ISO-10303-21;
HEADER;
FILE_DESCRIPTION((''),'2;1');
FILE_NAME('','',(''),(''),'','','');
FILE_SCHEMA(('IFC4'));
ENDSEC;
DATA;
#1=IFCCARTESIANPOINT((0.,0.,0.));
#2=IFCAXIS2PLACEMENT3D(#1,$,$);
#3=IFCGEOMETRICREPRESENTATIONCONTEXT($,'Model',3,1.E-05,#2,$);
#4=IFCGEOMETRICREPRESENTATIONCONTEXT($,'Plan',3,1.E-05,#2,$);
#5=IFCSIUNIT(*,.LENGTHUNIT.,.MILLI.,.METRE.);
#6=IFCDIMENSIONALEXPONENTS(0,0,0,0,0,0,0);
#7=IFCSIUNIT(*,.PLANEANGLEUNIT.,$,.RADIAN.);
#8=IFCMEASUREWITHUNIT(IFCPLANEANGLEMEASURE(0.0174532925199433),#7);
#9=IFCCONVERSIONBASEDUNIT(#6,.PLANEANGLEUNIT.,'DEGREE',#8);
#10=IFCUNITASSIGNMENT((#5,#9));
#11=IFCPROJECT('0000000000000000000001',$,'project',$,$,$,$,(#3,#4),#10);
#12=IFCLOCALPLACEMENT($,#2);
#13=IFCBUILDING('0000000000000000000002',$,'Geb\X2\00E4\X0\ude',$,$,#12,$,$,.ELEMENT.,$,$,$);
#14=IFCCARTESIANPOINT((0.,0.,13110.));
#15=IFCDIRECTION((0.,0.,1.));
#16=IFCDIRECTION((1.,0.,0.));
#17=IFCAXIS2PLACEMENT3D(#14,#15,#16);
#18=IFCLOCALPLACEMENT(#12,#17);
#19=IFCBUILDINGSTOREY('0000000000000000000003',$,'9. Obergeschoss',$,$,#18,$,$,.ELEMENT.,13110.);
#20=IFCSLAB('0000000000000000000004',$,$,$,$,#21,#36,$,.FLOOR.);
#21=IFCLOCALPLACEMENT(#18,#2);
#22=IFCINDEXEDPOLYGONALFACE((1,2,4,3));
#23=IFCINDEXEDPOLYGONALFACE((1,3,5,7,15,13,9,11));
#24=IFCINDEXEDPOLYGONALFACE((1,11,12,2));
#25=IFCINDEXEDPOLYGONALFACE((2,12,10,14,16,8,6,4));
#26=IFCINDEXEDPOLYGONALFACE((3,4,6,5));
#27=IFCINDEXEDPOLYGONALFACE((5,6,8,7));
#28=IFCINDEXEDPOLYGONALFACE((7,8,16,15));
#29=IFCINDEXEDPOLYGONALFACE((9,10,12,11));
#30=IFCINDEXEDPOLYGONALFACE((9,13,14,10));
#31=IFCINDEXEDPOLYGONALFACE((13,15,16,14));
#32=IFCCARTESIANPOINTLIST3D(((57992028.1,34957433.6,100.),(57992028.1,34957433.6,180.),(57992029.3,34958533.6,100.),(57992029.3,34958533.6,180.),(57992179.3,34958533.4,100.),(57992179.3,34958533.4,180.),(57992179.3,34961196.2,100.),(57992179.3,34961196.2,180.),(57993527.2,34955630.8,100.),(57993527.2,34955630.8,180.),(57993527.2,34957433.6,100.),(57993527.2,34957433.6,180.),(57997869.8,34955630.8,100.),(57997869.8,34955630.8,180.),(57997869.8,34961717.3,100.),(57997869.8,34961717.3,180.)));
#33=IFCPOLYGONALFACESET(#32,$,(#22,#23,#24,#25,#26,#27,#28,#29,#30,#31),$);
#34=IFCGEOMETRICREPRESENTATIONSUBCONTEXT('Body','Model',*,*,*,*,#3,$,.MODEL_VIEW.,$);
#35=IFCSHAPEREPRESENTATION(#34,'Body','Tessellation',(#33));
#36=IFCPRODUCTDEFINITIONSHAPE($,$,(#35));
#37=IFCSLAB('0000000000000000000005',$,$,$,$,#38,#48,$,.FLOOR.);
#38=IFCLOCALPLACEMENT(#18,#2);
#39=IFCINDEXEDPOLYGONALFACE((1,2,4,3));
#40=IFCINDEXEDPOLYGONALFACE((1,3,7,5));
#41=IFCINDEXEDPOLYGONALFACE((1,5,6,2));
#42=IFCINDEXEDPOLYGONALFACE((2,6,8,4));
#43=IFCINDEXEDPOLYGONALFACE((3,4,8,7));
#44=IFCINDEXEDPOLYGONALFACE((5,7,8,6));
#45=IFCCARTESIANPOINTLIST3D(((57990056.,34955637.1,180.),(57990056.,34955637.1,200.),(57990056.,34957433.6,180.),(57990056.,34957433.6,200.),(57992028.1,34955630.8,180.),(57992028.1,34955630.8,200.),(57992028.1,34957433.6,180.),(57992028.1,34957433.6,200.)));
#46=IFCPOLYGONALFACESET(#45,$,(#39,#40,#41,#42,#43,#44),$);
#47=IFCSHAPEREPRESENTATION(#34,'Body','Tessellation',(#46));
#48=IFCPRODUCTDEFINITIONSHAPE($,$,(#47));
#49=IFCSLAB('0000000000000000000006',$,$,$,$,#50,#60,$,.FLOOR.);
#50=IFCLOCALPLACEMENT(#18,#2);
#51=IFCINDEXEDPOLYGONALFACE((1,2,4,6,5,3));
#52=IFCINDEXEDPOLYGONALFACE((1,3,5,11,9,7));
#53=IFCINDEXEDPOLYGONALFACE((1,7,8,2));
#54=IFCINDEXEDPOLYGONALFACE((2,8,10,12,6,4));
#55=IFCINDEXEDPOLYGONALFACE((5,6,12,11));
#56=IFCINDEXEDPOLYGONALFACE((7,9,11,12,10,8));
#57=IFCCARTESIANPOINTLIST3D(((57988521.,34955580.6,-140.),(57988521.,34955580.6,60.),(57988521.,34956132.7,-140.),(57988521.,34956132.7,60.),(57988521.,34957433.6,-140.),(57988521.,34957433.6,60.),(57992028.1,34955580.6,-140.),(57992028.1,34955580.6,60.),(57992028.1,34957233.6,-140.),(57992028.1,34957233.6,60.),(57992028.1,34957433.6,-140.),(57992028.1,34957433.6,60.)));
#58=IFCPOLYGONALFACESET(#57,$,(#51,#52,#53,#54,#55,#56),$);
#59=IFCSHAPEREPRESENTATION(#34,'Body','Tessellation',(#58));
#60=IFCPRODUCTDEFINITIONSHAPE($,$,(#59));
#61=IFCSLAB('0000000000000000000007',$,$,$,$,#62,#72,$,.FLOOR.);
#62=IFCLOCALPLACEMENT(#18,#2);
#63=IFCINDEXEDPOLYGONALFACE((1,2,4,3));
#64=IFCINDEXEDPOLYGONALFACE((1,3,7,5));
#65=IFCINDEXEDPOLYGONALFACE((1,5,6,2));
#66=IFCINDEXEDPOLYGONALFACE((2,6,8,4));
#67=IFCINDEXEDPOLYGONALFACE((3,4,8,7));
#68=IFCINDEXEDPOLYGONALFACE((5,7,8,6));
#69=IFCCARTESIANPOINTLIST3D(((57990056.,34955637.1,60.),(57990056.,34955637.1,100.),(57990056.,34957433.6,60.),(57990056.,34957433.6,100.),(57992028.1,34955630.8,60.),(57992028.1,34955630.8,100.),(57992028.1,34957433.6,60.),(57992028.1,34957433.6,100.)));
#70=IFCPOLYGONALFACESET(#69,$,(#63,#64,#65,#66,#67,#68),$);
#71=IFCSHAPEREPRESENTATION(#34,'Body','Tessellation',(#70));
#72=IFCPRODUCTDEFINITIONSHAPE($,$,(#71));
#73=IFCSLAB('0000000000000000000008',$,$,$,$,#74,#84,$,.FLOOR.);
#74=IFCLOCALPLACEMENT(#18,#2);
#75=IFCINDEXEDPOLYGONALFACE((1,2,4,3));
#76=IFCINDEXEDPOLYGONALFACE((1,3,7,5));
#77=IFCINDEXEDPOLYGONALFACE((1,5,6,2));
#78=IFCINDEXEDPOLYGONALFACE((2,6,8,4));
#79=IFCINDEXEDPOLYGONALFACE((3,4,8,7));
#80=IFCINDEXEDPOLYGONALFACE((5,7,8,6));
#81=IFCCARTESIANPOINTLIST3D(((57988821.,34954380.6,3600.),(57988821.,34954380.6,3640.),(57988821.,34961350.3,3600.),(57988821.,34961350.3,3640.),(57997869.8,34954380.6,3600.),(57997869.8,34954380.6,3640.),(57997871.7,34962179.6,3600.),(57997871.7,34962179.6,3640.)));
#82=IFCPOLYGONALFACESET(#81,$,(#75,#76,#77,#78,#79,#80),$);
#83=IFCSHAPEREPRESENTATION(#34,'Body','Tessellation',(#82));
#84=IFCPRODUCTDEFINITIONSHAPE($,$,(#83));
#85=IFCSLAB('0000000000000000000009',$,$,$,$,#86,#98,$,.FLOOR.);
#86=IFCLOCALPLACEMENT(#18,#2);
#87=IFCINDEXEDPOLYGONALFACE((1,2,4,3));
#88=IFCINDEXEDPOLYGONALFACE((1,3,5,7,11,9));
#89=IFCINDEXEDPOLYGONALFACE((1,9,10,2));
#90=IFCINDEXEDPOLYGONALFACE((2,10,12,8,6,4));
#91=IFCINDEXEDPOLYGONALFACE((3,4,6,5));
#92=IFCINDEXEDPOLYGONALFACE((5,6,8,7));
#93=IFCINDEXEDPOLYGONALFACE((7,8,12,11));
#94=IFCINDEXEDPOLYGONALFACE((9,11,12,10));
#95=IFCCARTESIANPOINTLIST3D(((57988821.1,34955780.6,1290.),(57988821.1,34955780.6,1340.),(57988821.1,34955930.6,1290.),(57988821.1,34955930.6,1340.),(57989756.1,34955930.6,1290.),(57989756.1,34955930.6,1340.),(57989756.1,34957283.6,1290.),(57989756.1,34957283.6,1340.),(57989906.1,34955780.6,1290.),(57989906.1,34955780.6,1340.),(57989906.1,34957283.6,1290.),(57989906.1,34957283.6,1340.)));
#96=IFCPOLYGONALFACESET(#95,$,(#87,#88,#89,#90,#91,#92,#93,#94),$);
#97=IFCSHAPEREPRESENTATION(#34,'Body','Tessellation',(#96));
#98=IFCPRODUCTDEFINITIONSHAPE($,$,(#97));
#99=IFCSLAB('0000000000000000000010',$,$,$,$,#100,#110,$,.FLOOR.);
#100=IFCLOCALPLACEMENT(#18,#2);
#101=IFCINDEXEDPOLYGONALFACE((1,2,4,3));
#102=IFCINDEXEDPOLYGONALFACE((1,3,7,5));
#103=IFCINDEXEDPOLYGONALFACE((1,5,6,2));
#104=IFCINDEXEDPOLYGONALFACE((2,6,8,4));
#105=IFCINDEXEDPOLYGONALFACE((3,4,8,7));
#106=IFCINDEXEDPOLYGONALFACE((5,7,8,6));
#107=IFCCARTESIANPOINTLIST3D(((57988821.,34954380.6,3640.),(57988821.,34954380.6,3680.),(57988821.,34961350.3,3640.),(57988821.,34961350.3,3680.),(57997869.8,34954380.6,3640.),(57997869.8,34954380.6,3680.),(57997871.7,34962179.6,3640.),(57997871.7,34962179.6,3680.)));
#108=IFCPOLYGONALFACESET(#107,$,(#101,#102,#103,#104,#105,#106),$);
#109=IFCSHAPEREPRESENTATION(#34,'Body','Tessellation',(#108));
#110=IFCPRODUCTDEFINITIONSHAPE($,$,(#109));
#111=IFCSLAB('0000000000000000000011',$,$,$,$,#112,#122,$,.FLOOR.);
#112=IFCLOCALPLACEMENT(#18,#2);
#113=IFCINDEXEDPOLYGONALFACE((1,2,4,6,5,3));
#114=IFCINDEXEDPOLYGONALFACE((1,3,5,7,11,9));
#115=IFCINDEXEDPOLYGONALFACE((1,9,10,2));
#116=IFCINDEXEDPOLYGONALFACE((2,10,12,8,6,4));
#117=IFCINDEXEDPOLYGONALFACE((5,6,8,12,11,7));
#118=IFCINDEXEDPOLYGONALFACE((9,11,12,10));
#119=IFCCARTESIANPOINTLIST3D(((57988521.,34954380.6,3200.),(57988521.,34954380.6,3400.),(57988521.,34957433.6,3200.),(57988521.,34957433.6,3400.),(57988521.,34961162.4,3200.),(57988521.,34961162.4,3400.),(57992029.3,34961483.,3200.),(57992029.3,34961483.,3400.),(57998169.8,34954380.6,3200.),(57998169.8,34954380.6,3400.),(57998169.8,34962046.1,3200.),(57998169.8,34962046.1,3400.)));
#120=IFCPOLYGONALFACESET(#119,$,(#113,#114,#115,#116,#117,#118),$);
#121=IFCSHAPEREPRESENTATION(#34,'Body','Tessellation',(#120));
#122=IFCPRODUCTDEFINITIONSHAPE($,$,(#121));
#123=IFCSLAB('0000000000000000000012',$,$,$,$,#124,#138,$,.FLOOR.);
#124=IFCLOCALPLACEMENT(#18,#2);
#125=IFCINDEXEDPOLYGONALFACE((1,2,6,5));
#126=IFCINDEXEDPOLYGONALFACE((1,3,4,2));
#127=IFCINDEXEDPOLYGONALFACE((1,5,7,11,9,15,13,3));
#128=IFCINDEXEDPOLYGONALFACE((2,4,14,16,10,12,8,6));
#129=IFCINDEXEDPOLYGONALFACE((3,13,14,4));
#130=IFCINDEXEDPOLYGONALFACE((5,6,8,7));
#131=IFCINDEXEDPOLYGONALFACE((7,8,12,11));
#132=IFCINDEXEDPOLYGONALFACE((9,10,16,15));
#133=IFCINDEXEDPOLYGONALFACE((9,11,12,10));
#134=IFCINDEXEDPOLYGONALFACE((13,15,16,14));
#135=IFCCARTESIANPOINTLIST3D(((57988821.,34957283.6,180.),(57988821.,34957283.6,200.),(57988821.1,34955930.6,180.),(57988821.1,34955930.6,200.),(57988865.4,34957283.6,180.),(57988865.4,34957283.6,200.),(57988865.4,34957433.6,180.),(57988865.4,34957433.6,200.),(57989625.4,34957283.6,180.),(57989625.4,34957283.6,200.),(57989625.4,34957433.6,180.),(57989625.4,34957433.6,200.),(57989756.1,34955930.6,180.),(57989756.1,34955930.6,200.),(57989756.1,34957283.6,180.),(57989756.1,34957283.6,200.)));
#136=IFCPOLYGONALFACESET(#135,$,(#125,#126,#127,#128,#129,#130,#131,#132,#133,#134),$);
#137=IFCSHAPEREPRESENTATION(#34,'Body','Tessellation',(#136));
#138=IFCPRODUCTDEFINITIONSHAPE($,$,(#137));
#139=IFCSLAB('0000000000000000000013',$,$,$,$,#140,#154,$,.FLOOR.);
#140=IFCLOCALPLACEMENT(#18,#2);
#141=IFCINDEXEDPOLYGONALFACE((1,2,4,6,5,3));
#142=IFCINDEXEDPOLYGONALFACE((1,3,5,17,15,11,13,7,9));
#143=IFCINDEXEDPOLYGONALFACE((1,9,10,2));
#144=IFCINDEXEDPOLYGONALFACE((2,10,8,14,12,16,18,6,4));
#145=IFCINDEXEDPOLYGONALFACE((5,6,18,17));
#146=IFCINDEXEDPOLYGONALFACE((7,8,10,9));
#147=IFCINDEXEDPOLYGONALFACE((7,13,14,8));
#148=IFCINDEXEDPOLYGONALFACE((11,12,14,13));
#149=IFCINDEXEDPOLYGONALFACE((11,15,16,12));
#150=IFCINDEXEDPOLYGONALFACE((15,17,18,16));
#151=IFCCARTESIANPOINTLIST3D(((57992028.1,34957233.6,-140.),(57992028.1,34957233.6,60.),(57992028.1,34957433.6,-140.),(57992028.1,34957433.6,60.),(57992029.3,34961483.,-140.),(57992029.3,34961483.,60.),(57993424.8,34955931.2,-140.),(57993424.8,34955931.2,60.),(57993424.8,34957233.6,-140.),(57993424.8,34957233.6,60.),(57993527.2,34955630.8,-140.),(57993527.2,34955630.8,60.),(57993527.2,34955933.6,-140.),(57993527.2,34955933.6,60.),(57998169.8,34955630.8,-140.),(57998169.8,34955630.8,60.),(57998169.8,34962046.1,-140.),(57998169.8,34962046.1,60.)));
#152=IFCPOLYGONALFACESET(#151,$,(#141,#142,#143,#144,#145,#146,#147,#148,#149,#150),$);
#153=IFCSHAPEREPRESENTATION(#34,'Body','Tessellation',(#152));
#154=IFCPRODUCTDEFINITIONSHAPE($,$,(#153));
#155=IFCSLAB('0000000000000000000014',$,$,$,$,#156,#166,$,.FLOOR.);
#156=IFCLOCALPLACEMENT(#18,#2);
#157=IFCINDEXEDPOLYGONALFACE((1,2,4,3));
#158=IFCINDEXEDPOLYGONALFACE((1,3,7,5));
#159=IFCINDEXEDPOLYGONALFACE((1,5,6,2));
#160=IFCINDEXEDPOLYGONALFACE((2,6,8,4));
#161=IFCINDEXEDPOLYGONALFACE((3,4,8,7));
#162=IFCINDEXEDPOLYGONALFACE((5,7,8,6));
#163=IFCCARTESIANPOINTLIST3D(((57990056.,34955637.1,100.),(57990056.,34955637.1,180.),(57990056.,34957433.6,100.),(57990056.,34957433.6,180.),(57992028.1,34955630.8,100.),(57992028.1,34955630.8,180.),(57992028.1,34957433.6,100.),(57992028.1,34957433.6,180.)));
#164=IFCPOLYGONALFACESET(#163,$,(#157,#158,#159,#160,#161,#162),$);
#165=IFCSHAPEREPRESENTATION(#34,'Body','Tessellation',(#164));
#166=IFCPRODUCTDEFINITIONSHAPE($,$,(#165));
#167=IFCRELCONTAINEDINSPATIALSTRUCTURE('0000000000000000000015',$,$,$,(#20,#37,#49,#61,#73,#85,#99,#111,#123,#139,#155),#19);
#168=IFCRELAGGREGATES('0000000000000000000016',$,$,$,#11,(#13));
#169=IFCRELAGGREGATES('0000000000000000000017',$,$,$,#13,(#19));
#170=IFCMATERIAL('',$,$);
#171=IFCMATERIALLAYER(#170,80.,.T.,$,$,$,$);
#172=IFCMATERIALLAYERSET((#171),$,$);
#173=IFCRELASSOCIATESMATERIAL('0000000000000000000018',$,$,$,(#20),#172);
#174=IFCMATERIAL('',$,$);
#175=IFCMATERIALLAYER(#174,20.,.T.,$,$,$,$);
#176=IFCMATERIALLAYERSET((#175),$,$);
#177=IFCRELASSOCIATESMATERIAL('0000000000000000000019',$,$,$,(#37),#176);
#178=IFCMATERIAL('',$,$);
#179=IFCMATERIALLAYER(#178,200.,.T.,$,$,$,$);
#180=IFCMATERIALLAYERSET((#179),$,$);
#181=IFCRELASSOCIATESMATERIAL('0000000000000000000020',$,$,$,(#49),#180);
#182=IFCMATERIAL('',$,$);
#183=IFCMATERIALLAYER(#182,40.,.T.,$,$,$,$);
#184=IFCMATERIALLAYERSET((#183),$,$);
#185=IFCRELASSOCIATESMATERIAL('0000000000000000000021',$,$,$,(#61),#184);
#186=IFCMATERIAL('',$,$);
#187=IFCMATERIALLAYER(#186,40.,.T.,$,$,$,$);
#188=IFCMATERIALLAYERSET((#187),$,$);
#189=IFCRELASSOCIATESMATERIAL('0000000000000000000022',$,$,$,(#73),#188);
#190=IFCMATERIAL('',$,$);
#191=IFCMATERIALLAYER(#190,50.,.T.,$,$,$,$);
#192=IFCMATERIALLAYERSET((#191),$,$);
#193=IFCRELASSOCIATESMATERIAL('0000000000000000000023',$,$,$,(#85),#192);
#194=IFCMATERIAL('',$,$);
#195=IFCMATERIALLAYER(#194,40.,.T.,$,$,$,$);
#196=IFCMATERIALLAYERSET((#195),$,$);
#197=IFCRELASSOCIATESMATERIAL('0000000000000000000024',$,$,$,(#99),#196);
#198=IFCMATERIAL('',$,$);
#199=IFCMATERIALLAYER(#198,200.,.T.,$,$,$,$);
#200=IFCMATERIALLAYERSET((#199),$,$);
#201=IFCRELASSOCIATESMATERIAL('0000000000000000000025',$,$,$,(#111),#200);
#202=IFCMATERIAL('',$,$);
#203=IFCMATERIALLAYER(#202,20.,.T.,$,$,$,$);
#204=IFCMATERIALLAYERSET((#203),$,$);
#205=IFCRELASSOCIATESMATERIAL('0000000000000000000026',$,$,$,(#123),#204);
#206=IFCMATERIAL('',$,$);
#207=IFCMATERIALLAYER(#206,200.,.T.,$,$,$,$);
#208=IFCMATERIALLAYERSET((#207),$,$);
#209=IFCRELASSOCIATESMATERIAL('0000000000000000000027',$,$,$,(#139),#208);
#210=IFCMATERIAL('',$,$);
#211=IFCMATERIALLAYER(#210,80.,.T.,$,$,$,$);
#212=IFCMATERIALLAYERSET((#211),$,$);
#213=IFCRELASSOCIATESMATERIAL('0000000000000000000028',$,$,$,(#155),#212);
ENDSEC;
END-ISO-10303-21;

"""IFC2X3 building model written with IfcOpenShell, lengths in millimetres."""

from ifc_helpers import new_model, entity, si_unit, converted_unit, frame, origin, origin_with_axes, place, context, subcontext, project, spatial, polyline, outline, extrude, material, layer, layer_set, layer_usage, element, save


model = new_model("IFC2X3")

# Units and contexts
model_context = context("Model", 3, precision=1e-05, world=origin())
plan_context = context("Plan", 3, precision=1e-05, world=origin())
body_context = subcontext(model_context, "Body", "Model", "MODEL_VIEW")
ifc_project = project(units=[si_unit("LENGTHUNIT", "METRE", prefix="MILLI"), converted_unit("PLANEANGLEUNIT", "DEGREE", entity("IfcPlaneAngleMeasure", 0.0174532925199433), si_unit("PLANEANGLEUNIT", "RADIAN"), dimensions=[0, 0, 0, 0, 0, 0, 0])], contexts=[model_context, plan_context])

# Building, storey
building_placement = place(None, origin())
building = spatial("IfcBuilding", under=ifc_project, at=building_placement, Name="Gebäude", CompositionType="ELEMENT")
storey_placement = place(building_placement, frame((0.0, 0.0, 13110.0), z_axis=(0.0, 0.0, 1.0), x_axis=(1.0, 0.0, 0.0)))
storey = spatial("IfcBuildingStorey", under=building, at=storey_placement, Name="9. Obergeschoss", CompositionType="ELEMENT", Elevation=13110.0)

# Slabs
ifc_material_1 = material(Name="")
ifc_layer_1 = layer(ifc_material_1, 80.0, ventilated=True)
ifc_layer_set_1 = layer_set([ifc_layer_1])
ifc_layer_usage_1 = layer_usage(ifc_layer_set_1, "AXIS3", "POSITIVE", 0.0)
slab_1_placement = place(storey_placement, frame((57992028.1, 34955630.8, 100.0), z_axis=(0.0, 0.0, 1.0), x_axis=(1.0, 0.0, 0.0)))
element("IfcSlab", 1, at=slab_1_placement, inside=storey, material=ifc_layer_usage_1, PredefinedType="FLOOR", context=body_context, shape_type="SweptSolid", body=[
    extrude(outline(polyline([(0.0, 1802.7), (1499.1, 1802.7), (1499.1, 0.0), (5841.7, 0.0), (5841.7, 6086.5), (151.2, 5565.3), (151.2, 2902.6), (1.2, 2902.7), (0.0, 1802.7)])), origin_with_axes(), (0.0, 0.0, 1.0), 80.0),
])
ifc_material_2 = material(Name="")
ifc_layer_2 = layer(ifc_material_2, 20.0, ventilated=True)
ifc_layer_set_2 = layer_set([ifc_layer_2])
ifc_layer_usage_2 = layer_usage(ifc_layer_set_2, "AXIS3", "POSITIVE", 0.0)
slab_2_placement = place(storey_placement, frame((57990056.0, 34955630.8, 180.0), z_axis=(0.0, 0.0, 1.0), x_axis=(1.0, 0.0, 0.0)))
element("IfcSlab", 2, at=slab_2_placement, inside=storey, material=ifc_layer_usage_2, PredefinedType="FLOOR", context=body_context, shape_type="SweptSolid", body=[
    extrude(outline(polyline([(0.0, 1802.7), (0.0, 6.2), (1972.1, 0.0), (1972.1, 1802.7), (0.0, 1802.7)])), origin_with_axes(), (0.0, 0.0, 1.0), 20.0),
])
ifc_material_3 = material(Name="")
ifc_layer_3 = layer(ifc_material_3, 200.0, ventilated=True)
ifc_layer_set_3 = layer_set([ifc_layer_3])
ifc_layer_usage_3 = layer_usage(ifc_layer_set_3, "AXIS3", "POSITIVE", 0.0)
slab_3_placement = place(storey_placement, frame((57988521.0, 34955580.6, -140.0), z_axis=(0.0, 0.0, 1.0), x_axis=(1.0, 0.0, 0.0)))
element("IfcSlab", 3, at=slab_3_placement, inside=storey, material=ifc_layer_usage_3, PredefinedType="FLOOR", context=body_context, shape_type="SweptSolid", body=[
    extrude(outline(polyline([(0.0, 552.1), (0.0, 0.0), (3507.1, 0.0), (3507.1, 1653.0), (3507.1, 1853.0), (0.0, 1853.0), (0.0, 552.1)])), origin_with_axes(), (0.0, 0.0, 1.0), 200.0),
])
ifc_material_4 = material(Name="")
ifc_layer_4 = layer(ifc_material_4, 40.0, ventilated=True)
ifc_layer_set_4 = layer_set([ifc_layer_4])
ifc_layer_usage_4 = layer_usage(ifc_layer_set_4, "AXIS3", "POSITIVE", 0.0)
slab_4_placement = place(storey_placement, frame((57990056.0, 34955630.8, 60.0), z_axis=(0.0, 0.0, 1.0), x_axis=(1.0, 0.0, 0.0)))
element("IfcSlab", 4, at=slab_4_placement, inside=storey, material=ifc_layer_usage_4, PredefinedType="FLOOR", context=body_context, shape_type="SweptSolid", body=[
    extrude(outline(polyline([(0.0, 6.2), (1972.1, 0.0), (1972.1, 1802.7), (0.0, 1802.7), (0.0, 6.2)])), origin_with_axes(), (0.0, 0.0, 1.0), 40.0),
])
ifc_material_5 = material(Name="")
ifc_layer_5 = layer(ifc_material_5, 40.0, ventilated=True)
ifc_layer_set_5 = layer_set([ifc_layer_5])
ifc_layer_usage_5 = layer_usage(ifc_layer_set_5, "AXIS3", "POSITIVE", 0.0)
slab_5_placement = place(storey_placement, frame((57988821.0, 34954380.6, 3600.0), z_axis=(0.0, 0.0, 1.0), x_axis=(1.0, 0.0, 0.0)))
element("IfcSlab", 5, at=slab_5_placement, inside=storey, material=ifc_layer_usage_5, PredefinedType="FLOOR", context=body_context, shape_type="SweptSolid", body=[
    extrude(outline(polyline([(0.0, 0.0), (9048.8, 0.0), (9050.7, 7799.1), (0.0, 6969.7), (0.0, 0.0)])), origin_with_axes(), (0.0, 0.0, 1.0), 40.0),
])
ifc_material_6 = material(Name="")
ifc_layer_6 = layer(ifc_material_6, 50.0, ventilated=True)
ifc_layer_set_6 = layer_set([ifc_layer_6])
ifc_layer_usage_6 = layer_usage(ifc_layer_set_6, "AXIS3", "POSITIVE", 0.0)
slab_6_placement = place(storey_placement, frame((57988821.1, 34955780.6, 1290.0), z_axis=(0.0, 0.0, 1.0), x_axis=(1.0, 0.0, 0.0)))
element("IfcSlab", 6, at=slab_6_placement, inside=storey, material=ifc_layer_usage_6, PredefinedType="FLOOR", context=body_context, shape_type="SweptSolid", body=[
    extrude(outline(polyline([(935.0, 1503.0), (935.0, 150.0), (0.0, 150.0), (0.0, 0.0), (1085.0, 0.0), (1085.0, 1503.0), (935.0, 1503.0)])), origin_with_axes(), (0.0, 0.0, 1.0), 50.0),
])
ifc_material_7 = material(Name="")
ifc_layer_7 = layer(ifc_material_7, 40.0, ventilated=True)
ifc_layer_set_7 = layer_set([ifc_layer_7])
ifc_layer_usage_7 = layer_usage(ifc_layer_set_7, "AXIS3", "POSITIVE", 0.0)
slab_7_placement = place(storey_placement, frame((57988821.0, 34954380.6, 3640.0), z_axis=(0.0, 0.0, 1.0), x_axis=(1.0, 0.0, 0.0)))
element("IfcSlab", 7, at=slab_7_placement, inside=storey, material=ifc_layer_usage_7, PredefinedType="FLOOR", context=body_context, shape_type="SweptSolid", body=[
    extrude(outline(polyline([(0.0, 0.0), (9048.8, 0.0), (9050.7, 7799.1), (0.0, 6969.7), (0.0, 0.0)])), origin_with_axes(), (0.0, 0.0, 1.0), 40.0),
])
ifc_material_8 = material(Name="")
ifc_layer_8 = layer(ifc_material_8, 200.0, ventilated=True)
ifc_layer_set_8 = layer_set([ifc_layer_8])
ifc_layer_usage_8 = layer_usage(ifc_layer_set_8, "AXIS3", "POSITIVE", 0.0)
slab_8_placement = place(storey_placement, frame((57988521.0, 34954380.6, 3200.0), z_axis=(0.0, 0.0, 1.0), x_axis=(1.0, 0.0, 0.0)))
element("IfcSlab", 8, at=slab_8_placement, inside=storey, material=ifc_layer_usage_8, PredefinedType="FLOOR", context=body_context, shape_type="SweptSolid", body=[
    extrude(outline(polyline([(0.0, 0.0), (9648.8, 0.0), (9648.8, 7665.5), (3508.3, 7102.5), (0.0, 6781.8), (0.0, 3053.0), (0.0, 0.0)])), origin_with_axes(), (0.0, 0.0, 1.0), 200.0),
])
ifc_material_9 = material(Name="")
ifc_layer_9 = layer(ifc_material_9, 20.0, ventilated=True)
ifc_layer_set_9 = layer_set([ifc_layer_9])
ifc_layer_usage_9 = layer_usage(ifc_layer_set_9, "AXIS3", "POSITIVE", 0.0)
slab_9_placement = place(storey_placement, frame((57988821.0, 34955930.6, 180.0), z_axis=(0.0, 0.0, 1.0), x_axis=(1.0, 0.0, 0.0)))
element("IfcSlab", 9, at=slab_9_placement, inside=storey, material=ifc_layer_usage_9, PredefinedType="FLOOR", context=body_context, shape_type="SweptSolid", body=[
    extrude(outline(polyline([(0.0, 0.0), (935.0, 0.0), (935.0, 1353.0), (804.3, 1353.0), (804.3, 1503.0), (44.3, 1503.0), (44.3, 1353.0), (0.0, 1353.0), (0.0, 0.0)])), origin_with_axes(), (0.0, 0.0, 1.0), 20.0),
])
ifc_material_10 = material(Name="")
ifc_layer_10 = layer(ifc_material_10, 200.0, ventilated=True)
ifc_layer_set_10 = layer_set([ifc_layer_10])
ifc_layer_usage_10 = layer_usage(ifc_layer_set_10, "AXIS3", "POSITIVE", 0.0)
slab_10_placement = place(storey_placement, frame((57992028.1, 34955630.8, -140.0), z_axis=(0.0, 0.0, 1.0), x_axis=(1.0, 0.0, 0.0)))
element("IfcSlab", 10, at=slab_10_placement, inside=storey, material=ifc_layer_usage_10, PredefinedType="FLOOR", context=body_context, shape_type="SweptSolid", body=[
    extrude(outline(polyline([(0.0, 1602.7), (1396.7, 1602.7), (1396.7, 300.4), (1499.1, 302.8), (1499.1, 0.0), (6141.7, 0.0), (6141.7, 6415.3), (1.2, 5852.2), (0.0, 1802.7), (0.0, 1602.7)])), origin_with_axes(), (0.0, 0.0, 1.0), 200.0),
])
ifc_material_11 = material(Name="")
ifc_layer_11 = layer(ifc_material_11, 80.0, ventilated=True)
ifc_layer_set_11 = layer_set([ifc_layer_11])
ifc_layer_usage_11 = layer_usage(ifc_layer_set_11, "AXIS3", "POSITIVE", 0.0)
slab_11_placement = place(storey_placement, frame((57990056.0, 34955630.8, 100.0), z_axis=(0.0, 0.0, 1.0), x_axis=(1.0, 0.0, 0.0)))
element("IfcSlab", 11, at=slab_11_placement, inside=storey, material=ifc_layer_usage_11, PredefinedType="FLOOR", context=body_context, shape_type="SweptSolid", body=[
    extrude(outline(polyline([(0.0, 6.2), (1972.1, 0.0), (1972.1, 1802.7), (0.0, 1802.7), (0.0, 6.2)])), origin_with_axes(), (0.0, 0.0, 1.0), 80.0),
])

save(model, "model.ifc")
